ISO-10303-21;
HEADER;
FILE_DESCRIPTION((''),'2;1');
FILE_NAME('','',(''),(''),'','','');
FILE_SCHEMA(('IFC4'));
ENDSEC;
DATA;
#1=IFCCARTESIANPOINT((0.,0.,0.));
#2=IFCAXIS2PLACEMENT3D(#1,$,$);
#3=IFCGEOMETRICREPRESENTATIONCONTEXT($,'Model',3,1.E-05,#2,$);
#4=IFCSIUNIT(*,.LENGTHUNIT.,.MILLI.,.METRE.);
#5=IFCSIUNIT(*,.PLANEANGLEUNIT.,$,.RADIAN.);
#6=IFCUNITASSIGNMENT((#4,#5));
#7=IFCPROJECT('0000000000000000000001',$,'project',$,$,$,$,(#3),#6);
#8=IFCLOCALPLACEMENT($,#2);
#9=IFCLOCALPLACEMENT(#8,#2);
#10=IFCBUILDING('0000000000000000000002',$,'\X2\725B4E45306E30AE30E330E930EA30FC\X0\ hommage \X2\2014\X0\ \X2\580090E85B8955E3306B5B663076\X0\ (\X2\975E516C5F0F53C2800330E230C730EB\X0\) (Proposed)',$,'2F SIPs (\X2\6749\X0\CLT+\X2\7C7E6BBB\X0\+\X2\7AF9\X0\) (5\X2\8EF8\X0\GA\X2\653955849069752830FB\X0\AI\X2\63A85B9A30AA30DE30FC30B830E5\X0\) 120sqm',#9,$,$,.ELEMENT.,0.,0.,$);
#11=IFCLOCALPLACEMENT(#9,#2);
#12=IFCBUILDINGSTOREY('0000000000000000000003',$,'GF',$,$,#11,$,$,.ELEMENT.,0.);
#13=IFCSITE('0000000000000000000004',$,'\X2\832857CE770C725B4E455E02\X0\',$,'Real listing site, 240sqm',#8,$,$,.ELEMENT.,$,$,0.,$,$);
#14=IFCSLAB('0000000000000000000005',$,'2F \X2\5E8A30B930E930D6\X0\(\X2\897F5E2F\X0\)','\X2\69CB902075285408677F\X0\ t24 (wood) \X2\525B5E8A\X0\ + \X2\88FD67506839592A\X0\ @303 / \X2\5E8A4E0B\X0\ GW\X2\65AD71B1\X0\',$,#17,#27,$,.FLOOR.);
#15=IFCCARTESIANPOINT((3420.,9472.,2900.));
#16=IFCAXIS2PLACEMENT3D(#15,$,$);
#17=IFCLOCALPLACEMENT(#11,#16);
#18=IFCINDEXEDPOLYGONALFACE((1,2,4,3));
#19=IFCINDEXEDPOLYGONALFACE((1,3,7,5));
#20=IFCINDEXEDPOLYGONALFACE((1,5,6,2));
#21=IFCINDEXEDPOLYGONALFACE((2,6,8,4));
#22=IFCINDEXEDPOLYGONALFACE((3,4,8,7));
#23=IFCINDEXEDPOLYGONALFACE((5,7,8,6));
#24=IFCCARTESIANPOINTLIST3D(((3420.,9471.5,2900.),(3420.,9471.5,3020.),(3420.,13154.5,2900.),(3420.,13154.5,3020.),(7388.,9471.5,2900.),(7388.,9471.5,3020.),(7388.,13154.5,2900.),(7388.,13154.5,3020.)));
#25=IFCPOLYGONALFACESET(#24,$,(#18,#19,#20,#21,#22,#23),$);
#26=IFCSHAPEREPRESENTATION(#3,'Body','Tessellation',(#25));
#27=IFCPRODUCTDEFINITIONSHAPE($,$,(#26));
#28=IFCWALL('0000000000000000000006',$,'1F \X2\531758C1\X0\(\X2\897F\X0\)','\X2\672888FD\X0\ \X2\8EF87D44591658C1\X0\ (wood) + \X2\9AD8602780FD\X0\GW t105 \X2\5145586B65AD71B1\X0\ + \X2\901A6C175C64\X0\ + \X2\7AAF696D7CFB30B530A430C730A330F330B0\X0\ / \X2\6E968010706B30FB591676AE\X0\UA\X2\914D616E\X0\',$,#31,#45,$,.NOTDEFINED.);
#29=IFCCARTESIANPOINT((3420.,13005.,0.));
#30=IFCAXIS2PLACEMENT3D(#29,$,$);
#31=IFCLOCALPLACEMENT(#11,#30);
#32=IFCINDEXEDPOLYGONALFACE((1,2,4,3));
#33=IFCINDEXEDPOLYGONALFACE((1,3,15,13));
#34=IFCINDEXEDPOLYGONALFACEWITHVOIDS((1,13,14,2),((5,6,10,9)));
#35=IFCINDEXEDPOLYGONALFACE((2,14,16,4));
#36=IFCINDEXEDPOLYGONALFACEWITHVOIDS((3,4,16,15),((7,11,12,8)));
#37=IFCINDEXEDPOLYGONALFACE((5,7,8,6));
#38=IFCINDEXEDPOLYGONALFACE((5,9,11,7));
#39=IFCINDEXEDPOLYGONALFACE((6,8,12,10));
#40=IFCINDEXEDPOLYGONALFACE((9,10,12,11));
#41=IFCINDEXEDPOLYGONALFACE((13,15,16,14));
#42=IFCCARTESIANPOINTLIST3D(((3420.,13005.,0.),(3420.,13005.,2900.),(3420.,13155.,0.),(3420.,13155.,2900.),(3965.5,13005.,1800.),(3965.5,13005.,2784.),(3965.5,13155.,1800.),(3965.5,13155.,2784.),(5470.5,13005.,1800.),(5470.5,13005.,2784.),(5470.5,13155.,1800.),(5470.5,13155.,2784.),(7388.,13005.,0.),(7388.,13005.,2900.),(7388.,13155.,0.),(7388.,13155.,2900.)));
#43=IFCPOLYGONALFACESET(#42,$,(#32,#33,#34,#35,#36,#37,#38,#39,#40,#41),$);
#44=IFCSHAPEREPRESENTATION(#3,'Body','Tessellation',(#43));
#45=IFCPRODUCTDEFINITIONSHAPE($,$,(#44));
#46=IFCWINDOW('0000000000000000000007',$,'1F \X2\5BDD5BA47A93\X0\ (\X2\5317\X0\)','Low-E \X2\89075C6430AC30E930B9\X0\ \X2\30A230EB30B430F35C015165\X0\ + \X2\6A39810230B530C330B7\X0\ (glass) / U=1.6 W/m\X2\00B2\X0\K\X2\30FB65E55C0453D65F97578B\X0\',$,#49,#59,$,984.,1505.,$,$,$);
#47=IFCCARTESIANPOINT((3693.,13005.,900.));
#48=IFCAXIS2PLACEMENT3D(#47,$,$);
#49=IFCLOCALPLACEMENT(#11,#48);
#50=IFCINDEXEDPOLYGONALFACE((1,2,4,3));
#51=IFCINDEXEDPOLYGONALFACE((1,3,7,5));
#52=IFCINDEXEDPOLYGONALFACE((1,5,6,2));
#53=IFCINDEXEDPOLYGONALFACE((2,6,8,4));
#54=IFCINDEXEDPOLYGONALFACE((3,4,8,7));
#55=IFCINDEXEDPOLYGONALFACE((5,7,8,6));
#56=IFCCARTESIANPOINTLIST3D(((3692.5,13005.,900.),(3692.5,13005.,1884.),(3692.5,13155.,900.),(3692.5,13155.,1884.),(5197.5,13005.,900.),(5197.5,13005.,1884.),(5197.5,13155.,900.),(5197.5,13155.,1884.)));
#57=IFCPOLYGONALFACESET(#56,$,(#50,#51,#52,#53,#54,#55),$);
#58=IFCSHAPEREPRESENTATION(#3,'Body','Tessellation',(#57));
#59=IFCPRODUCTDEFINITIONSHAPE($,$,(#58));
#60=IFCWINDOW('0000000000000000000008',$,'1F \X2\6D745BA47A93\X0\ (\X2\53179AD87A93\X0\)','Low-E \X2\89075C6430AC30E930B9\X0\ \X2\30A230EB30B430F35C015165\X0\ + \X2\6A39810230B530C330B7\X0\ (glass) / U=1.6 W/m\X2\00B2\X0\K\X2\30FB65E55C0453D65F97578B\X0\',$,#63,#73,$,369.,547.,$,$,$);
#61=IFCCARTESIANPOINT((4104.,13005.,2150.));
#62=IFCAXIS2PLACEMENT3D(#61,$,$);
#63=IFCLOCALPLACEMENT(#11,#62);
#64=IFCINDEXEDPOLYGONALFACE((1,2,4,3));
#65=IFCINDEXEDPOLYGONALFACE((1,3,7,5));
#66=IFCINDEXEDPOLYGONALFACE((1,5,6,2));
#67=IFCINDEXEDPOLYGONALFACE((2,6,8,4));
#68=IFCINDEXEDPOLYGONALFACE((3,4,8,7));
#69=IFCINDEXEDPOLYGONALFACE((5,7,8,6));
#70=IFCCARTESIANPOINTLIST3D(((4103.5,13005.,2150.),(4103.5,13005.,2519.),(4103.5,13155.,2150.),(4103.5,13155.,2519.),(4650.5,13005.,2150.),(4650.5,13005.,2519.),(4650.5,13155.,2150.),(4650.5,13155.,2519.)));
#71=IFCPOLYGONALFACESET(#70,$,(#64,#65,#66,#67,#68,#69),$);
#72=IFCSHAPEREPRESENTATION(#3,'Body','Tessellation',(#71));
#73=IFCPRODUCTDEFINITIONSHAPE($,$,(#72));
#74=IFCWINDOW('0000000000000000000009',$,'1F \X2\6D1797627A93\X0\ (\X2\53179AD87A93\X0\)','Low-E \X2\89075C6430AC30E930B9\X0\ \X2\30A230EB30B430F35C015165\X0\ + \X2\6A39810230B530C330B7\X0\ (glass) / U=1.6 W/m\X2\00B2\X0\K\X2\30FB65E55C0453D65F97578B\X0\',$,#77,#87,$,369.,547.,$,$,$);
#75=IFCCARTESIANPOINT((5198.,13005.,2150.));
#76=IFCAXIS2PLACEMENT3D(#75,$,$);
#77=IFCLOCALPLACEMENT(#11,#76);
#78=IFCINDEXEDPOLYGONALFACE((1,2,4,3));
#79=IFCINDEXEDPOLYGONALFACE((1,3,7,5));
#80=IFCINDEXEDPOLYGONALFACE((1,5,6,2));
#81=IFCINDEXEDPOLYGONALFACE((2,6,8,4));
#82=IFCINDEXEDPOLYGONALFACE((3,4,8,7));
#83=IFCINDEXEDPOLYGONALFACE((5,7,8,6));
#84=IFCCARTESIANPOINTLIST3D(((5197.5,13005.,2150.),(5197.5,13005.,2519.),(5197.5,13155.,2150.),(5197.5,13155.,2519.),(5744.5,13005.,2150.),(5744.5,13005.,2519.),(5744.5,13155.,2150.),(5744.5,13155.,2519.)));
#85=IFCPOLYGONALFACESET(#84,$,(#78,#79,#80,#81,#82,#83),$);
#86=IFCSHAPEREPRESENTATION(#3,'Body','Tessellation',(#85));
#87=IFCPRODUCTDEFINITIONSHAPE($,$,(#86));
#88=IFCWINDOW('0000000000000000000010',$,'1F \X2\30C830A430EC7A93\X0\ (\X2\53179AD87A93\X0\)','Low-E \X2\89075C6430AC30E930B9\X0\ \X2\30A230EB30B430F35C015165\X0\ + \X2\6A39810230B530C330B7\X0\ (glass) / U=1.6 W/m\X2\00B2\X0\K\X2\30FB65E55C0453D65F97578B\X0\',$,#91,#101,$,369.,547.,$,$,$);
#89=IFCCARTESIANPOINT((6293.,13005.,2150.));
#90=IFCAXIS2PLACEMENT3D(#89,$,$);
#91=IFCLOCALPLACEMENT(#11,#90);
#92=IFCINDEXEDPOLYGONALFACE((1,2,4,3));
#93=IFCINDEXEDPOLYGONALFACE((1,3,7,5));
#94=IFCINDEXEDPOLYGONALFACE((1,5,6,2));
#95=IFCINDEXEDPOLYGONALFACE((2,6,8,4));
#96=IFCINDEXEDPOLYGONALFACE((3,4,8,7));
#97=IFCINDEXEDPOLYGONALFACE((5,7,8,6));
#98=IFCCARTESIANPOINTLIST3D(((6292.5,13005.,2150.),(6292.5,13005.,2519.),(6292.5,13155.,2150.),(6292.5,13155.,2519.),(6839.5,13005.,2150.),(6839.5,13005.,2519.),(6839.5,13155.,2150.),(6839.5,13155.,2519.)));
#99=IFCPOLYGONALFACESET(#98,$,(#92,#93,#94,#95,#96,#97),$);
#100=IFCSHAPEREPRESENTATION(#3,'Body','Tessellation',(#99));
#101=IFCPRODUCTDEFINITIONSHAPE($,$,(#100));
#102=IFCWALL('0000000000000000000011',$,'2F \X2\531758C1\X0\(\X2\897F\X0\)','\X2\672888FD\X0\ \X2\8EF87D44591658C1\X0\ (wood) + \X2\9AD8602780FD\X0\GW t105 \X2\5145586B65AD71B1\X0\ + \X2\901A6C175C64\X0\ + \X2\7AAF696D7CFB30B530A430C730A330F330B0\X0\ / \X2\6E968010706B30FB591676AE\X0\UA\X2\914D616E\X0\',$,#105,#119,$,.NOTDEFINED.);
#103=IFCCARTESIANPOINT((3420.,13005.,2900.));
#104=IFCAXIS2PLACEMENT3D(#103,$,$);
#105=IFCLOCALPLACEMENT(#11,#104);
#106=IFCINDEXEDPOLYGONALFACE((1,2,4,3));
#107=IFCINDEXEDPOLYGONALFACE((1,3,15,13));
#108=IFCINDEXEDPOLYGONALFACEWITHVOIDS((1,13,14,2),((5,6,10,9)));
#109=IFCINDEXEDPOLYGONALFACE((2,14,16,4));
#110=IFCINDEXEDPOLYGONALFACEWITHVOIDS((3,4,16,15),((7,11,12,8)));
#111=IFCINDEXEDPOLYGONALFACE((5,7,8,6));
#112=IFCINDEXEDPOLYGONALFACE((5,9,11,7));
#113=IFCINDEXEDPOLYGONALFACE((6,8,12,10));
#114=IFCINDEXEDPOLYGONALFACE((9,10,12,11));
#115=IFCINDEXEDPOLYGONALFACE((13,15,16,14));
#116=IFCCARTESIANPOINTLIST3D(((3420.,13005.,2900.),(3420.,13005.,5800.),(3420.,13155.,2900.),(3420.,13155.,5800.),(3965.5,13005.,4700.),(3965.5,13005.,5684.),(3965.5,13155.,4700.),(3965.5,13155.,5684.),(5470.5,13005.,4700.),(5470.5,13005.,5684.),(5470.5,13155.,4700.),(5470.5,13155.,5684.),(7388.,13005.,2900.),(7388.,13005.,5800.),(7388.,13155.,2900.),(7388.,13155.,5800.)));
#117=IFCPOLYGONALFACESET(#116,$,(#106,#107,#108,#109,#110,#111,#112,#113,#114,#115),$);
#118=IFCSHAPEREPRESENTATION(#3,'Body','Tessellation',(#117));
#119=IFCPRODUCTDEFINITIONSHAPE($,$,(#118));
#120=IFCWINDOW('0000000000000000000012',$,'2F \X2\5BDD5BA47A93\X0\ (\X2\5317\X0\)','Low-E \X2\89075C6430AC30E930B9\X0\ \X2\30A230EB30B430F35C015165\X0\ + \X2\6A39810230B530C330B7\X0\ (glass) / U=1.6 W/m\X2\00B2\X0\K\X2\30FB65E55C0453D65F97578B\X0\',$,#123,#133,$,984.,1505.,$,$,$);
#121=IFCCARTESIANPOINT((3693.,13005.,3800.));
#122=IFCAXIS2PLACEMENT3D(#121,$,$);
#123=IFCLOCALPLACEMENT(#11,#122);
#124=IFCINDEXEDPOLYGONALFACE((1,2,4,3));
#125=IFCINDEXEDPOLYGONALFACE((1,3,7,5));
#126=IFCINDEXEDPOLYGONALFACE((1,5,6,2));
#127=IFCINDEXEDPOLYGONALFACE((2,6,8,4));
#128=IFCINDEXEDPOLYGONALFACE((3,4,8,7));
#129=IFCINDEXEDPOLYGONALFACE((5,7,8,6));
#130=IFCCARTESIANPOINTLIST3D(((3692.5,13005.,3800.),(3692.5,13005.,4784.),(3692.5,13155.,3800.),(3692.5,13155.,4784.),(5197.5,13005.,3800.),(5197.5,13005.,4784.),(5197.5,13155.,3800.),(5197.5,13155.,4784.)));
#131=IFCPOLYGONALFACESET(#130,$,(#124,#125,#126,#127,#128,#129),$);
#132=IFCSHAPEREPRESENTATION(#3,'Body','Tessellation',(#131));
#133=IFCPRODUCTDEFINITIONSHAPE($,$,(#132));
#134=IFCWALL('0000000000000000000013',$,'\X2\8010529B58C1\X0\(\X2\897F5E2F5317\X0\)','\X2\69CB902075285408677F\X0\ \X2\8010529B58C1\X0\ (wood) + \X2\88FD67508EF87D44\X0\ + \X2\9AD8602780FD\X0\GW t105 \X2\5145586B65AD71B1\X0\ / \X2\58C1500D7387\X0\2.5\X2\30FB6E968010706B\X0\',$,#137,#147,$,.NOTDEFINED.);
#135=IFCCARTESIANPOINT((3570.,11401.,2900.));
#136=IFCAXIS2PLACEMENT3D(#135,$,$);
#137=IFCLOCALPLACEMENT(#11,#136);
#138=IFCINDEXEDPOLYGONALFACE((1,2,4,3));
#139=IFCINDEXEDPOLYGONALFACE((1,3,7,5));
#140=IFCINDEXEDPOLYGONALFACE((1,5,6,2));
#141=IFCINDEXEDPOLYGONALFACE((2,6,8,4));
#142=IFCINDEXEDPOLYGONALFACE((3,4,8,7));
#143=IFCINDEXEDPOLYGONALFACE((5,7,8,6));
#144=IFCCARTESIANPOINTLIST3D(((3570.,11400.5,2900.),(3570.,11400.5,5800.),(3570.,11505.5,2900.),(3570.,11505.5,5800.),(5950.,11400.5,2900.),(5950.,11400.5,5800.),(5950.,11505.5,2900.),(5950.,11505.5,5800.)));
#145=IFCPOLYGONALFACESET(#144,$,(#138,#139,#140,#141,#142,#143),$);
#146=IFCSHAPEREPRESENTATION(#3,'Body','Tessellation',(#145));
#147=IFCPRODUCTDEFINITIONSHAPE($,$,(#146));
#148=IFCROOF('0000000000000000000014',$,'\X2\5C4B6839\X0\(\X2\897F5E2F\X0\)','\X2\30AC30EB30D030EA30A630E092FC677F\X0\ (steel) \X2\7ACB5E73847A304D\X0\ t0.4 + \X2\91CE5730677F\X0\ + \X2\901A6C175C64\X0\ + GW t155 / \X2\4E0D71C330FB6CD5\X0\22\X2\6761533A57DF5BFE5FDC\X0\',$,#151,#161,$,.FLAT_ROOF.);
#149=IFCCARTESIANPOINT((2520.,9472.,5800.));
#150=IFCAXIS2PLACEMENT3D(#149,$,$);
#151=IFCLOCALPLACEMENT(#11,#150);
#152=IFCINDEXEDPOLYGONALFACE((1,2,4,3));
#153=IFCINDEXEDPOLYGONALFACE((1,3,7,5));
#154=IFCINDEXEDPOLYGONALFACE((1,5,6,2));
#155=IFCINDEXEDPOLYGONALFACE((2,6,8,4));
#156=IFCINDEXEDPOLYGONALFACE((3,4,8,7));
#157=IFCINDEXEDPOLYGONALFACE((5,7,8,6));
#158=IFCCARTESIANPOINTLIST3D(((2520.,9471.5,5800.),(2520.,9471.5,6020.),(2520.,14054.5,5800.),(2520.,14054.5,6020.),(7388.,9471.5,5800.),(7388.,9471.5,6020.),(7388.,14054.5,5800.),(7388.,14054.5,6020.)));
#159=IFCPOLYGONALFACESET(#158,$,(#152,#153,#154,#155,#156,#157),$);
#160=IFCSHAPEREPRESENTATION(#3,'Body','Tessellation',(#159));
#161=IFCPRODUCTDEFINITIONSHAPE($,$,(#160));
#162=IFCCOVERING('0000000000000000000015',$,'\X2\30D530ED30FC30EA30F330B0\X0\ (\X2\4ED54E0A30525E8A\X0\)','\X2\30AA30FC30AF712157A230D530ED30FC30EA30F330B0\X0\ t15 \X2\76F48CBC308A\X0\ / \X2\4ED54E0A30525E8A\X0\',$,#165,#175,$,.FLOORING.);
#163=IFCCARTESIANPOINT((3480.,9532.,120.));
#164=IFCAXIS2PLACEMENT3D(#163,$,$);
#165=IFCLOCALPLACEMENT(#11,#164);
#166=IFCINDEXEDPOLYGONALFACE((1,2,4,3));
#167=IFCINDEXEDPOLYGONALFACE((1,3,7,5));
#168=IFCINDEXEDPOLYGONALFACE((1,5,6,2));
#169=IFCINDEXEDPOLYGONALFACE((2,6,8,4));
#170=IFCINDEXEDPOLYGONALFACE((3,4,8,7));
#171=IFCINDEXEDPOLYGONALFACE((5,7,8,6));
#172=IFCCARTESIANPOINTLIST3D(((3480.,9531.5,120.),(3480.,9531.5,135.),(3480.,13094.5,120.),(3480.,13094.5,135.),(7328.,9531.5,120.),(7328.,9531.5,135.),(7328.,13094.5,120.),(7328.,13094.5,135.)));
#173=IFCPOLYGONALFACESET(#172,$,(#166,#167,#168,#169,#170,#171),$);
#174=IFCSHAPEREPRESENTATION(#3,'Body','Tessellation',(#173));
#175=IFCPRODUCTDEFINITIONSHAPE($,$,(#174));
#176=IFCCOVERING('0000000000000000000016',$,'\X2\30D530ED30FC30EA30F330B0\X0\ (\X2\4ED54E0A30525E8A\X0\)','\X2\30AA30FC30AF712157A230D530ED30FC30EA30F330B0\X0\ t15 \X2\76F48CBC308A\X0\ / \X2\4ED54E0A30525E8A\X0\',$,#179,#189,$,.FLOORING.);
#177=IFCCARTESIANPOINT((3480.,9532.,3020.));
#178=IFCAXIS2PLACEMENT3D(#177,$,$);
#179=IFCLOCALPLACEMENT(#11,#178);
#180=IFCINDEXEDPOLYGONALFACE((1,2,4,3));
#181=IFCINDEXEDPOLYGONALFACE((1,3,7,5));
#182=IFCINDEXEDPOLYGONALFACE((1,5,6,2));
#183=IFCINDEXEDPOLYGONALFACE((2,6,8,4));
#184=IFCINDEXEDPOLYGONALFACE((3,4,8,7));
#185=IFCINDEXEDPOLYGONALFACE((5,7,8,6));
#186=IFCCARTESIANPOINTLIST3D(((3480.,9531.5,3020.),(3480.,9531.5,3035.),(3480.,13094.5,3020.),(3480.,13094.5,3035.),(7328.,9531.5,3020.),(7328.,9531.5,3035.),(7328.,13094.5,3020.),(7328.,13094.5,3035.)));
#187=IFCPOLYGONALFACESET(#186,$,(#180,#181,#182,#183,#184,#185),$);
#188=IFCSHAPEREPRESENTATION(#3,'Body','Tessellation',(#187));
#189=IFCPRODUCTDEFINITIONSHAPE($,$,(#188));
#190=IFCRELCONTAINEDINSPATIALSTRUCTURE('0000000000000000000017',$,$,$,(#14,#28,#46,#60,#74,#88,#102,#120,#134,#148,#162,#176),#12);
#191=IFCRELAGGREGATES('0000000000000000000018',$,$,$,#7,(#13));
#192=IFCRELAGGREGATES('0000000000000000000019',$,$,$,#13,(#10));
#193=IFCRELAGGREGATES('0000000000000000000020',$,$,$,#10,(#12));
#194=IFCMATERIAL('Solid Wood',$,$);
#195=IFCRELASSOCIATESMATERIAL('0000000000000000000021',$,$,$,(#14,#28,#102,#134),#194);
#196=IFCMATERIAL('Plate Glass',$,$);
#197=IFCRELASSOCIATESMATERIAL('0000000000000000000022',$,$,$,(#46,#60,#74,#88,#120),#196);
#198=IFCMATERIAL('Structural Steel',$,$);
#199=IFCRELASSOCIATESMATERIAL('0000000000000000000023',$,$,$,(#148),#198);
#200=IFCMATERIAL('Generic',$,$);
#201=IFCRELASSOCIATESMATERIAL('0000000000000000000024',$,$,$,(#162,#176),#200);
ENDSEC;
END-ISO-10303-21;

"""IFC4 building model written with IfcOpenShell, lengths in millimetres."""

from ifc_helpers import new_model, si_unit, frame, frame_2d, origin, place, context, project, spatial, rectangle, extrude, material, element, fill, save


model = new_model("IFC4")

# Units and contexts
model_context = context("Model", 3, precision=1e-05, world=origin())
ifc_project = project(units=[si_unit("LENGTHUNIT", "METRE", prefix="MILLI"), si_unit("PLANEANGLEUNIT", "RADIAN")], contexts=[model_context])

# Site, building, storey
site_placement = place(None, origin())
site = spatial("IfcSite", under=ifc_project, at=site_placement, Name="茨城県牛久市", ObjectType="Real listing site, 240sqm", CompositionType="ELEMENT", RefElevation=0.0)
building_placement = place(site_placement, origin())
building = spatial("IfcBuilding", under=site, at=building_placement, Name="牛久のギャラリー hommage — 堀部安嗣に学ぶ (非公式参考モデル) (Proposed)", ObjectType="2F SIPs (杉CLT+籾殻+竹) (5軸GA改善適用・AI推定オマージュ) 120sqm", CompositionType="ELEMENT", ElevationOfRefHeight=0.0, ElevationOfTerrain=0.0)
storey_placement = place(building_placement, origin())
storey = spatial("IfcBuildingStorey", under=building, at=storey_placement, Name="GF", CompositionType="ELEMENT", Elevation=0.0)

# Slab
ifc_material_1 = material(Name="Solid Wood")
slab_1_placement = place(storey_placement, frame((3420.0, 9472.0, 2900.0)))
element("IfcSlab", 1, at=slab_1_placement, inside=storey, material=ifc_material_1, Name="2F 床スラブ(西帯)", Description="構造用合板 t24 (wood) 剛床 + 製材根太 @303 / 床下 GW断熱", PredefinedType="FLOOR", context=model_context, shape_type="SweptSolid", body=[
    extrude(rectangle(XDim=3968.0, YDim=3683.0, at=frame_2d((1984.0, 1841.0))), frame((3420.0, 9472.0, 2900.0)), (0.0, 0.0, 1.0), 120.0),
])

# Wall, openings, windows
wall_1_placement = place(storey_placement, frame((3420.0, 13005.0, 0.0)))
wall_1 = element("IfcWall", 2, at=wall_1_placement, inside=storey, material=ifc_material_1, Name="1F 北壁(西)", Description="木製 軸組外壁 (wood) + 高性能GW t105 充填断熱 + 通気層 + 窯業系サイディング / 準耐火・外皮UA配慮", PredefinedType="NOTDEFINED", context=model_context, shape_type="SweptSolid", body=[
    extrude(rectangle(XDim=3968.0, YDim=150.0, at=frame_2d((1984.0, 75.0))), frame((3420.0, 13005.0, 0.0)), (0.0, 0.0, 1.0), 2900.0),
])
opening_1_placement = place(storey_placement, frame((3693.0, 13005.0, 900.0)))
opening_1 = element("IfcOpeningElement", 3, at=opening_1_placement, cuts=wall_1, PredefinedType="NOTDEFINED", context=model_context, shape_type="SweptSolid", body=[
    extrude(rectangle(XDim=1505.0, YDim=150.0, at=frame_2d((752.0, 75.0))), frame((3693.0, 13005.0, 900.0)), (0.0, 0.0, 1.0), 984.0),
])
opening_2_placement = place(storey_placement, frame((4104.0, 13005.0, 2150.0)))
opening_2 = element("IfcOpeningElement", 4, at=opening_2_placement, cuts=wall_1, PredefinedType="NOTDEFINED", context=model_context, shape_type="SweptSolid", body=[
    extrude(rectangle(XDim=547.0, YDim=150.0, at=frame_2d((273.0, 75.0))), frame((4104.0, 13005.0, 2150.0)), (0.0, 0.0, 1.0), 369.0),
])
opening_3_placement = place(storey_placement, frame((5198.0, 13005.0, 2150.0)))
opening_3 = element("IfcOpeningElement", 5, at=opening_3_placement, cuts=wall_1, PredefinedType="NOTDEFINED", context=model_context, shape_type="SweptSolid", body=[
    extrude(rectangle(XDim=547.0, YDim=150.0, at=frame_2d((273.0, 75.0))), frame((5198.0, 13005.0, 2150.0)), (0.0, 0.0, 1.0), 369.0),
])
opening_4_placement = place(storey_placement, frame((6293.0, 13005.0, 2150.0)))
opening_4 = element("IfcOpeningElement", 6, at=opening_4_placement, cuts=wall_1, PredefinedType="NOTDEFINED", context=model_context, shape_type="SweptSolid", body=[
    extrude(rectangle(XDim=547.0, YDim=150.0, at=frame_2d((273.0, 75.0))), frame((6293.0, 13005.0, 2150.0)), (0.0, 0.0, 1.0), 369.0),
])
ifc_material_2 = material(Name="Plate Glass")
window_1_placement = place(storey_placement, frame((3693.0, 13005.0, 900.0)))
window_1 = element("IfcWindow", 7, at=window_1_placement, inside=storey, material=ifc_material_2, Name="1F 寝室窓 (北)", Description="Low-E 複層ガラス アルゴン封入 + 樹脂サッシ (glass) / U=1.6 W/m²K・日射取得型", OverallHeight=984.0, OverallWidth=1505.0, context=model_context, shape_type="SweptSolid", body=[
    extrude(rectangle(XDim=1505.0, YDim=150.0, at=frame_2d((752.0, 75.0))), frame((3693.0, 13005.0, 900.0)), (0.0, 0.0, 1.0), 984.0),
])
fill(opening_1, window_1)
window_2_placement = place(storey_placement, frame((4104.0, 13005.0, 2150.0)))
window_2 = element("IfcWindow", 8, at=window_2_placement, inside=storey, material=ifc_material_2, Name="1F 浴室窓 (北高窓)", Description="Low-E 複層ガラス アルゴン封入 + 樹脂サッシ (glass) / U=1.6 W/m²K・日射取得型", OverallHeight=369.0, OverallWidth=547.0, context=model_context, shape_type="SweptSolid", body=[
    extrude(rectangle(XDim=547.0, YDim=150.0, at=frame_2d((273.0, 75.0))), frame((4104.0, 13005.0, 2150.0)), (0.0, 0.0, 1.0), 369.0),
])
fill(opening_2, window_2)
window_3_placement = place(storey_placement, frame((5198.0, 13005.0, 2150.0)))
window_3 = element("IfcWindow", 9, at=window_3_placement, inside=storey, material=ifc_material_2, Name="1F 洗面窓 (北高窓)", Description="Low-E 複層ガラス アルゴン封入 + 樹脂サッシ (glass) / U=1.6 W/m²K・日射取得型", OverallHeight=369.0, OverallWidth=547.0, context=model_context, shape_type="SweptSolid", body=[
    extrude(rectangle(XDim=547.0, YDim=150.0, at=frame_2d((273.0, 75.0))), frame((5198.0, 13005.0, 2150.0)), (0.0, 0.0, 1.0), 369.0),
])
fill(opening_3, window_3)
window_4_placement = place(storey_placement, frame((6293.0, 13005.0, 2150.0)))
window_4 = element("IfcWindow", 10, at=window_4_placement, inside=storey, material=ifc_material_2, Name="1F トイレ窓 (北高窓)", Description="Low-E 複層ガラス アルゴン封入 + 樹脂サッシ (glass) / U=1.6 W/m²K・日射取得型", OverallHeight=369.0, OverallWidth=547.0, context=model_context, shape_type="SweptSolid", body=[
    extrude(rectangle(XDim=547.0, YDim=150.0, at=frame_2d((273.0, 75.0))), frame((6293.0, 13005.0, 2150.0)), (0.0, 0.0, 1.0), 369.0),
])
fill(opening_4, window_4)

# Wall, opening, window
wall_2_placement = place(storey_placement, frame((3420.0, 13005.0, 2900.0)))
wall_2 = element("IfcWall", 11, at=wall_2_placement, inside=storey, material=ifc_material_1, Name="2F 北壁(西)", Description="木製 軸組外壁 (wood) + 高性能GW t105 充填断熱 + 通気層 + 窯業系サイディング / 準耐火・外皮UA配慮", PredefinedType="NOTDEFINED", context=model_context, shape_type="SweptSolid", body=[
    extrude(rectangle(XDim=3968.0, YDim=150.0, at=frame_2d((1984.0, 75.0))), frame((3420.0, 13005.0, 2900.0)), (0.0, 0.0, 1.0), 2900.0),
])
opening_5_placement = place(storey_placement, frame((3693.0, 13005.0, 3800.0)))
opening_5 = element("IfcOpeningElement", 12, at=opening_5_placement, cuts=wall_2, PredefinedType="NOTDEFINED", context=model_context, shape_type="SweptSolid", body=[
    extrude(rectangle(XDim=1505.0, YDim=150.0, at=frame_2d((752.0, 75.0))), frame((3693.0, 13005.0, 3800.0)), (0.0, 0.0, 1.0), 984.0),
])
window_5_placement = place(storey_placement, frame((3693.0, 13005.0, 3800.0)))
window_5 = element("IfcWindow", 13, at=window_5_placement, inside=storey, material=ifc_material_2, Name="2F 寝室窓 (北)", Description="Low-E 複層ガラス アルゴン封入 + 樹脂サッシ (glass) / U=1.6 W/m²K・日射取得型", OverallHeight=984.0, OverallWidth=1505.0, context=model_context, shape_type="SweptSolid", body=[
    extrude(rectangle(XDim=1505.0, YDim=150.0, at=frame_2d((752.0, 75.0))), frame((3693.0, 13005.0, 3800.0)), (0.0, 0.0, 1.0), 984.0),
])
fill(opening_5, window_5)

# Wall
wall_3_placement = place(storey_placement, frame((3570.0, 11401.0, 2900.0)))
element("IfcWall", 14, at=wall_3_placement, inside=storey, material=ifc_material_1, Name="耐力壁(西帯北)", Description="構造用合板 耐力壁 (wood) + 製材軸組 + 高性能GW t105 充填断熱 / 壁倍率2.5・準耐火", PredefinedType="NOTDEFINED", context=model_context, shape_type="SweptSolid", body=[
    extrude(rectangle(XDim=2380.0, YDim=105.0, at=frame_2d((1190.0, 52.0))), frame((3570.0, 11401.0, 2900.0)), (0.0, 0.0, 1.0), 2900.0),
])

# Roof
ifc_material_3 = material(Name="Structural Steel")
for number, where, name in (
    (15, (2520.0, 9472.0, 5800.0), "屋根(西帯)"),
):
    element("IfcRoof", number, at=place(storey_placement, frame(where)), inside=storey, material=ifc_material_3, Name=name, Description="ガルバリウム鋼板 (steel) 立平葺き t0.4 + 野地板 + 通気層 + GW t155 / 不燃・法22条区域対応", PredefinedType="FLAT_ROOF", context=model_context, shape_type="SweptSolid", body=[
        extrude(rectangle(XDim=4868.0, YDim=4583.0, at=frame_2d((2434.0, 2291.0))), frame((2520.0, 9472.0, 5800.0)), (0.0, 0.0, 1.0), 220.0),
    ])

# Coverings
ifc_material_4 = material(Name="Generic")
covering_1_placement = place(storey_placement, frame((3480.0, 9532.0, 120.0)))
element("IfcCovering", 16, at=covering_1_placement, inside=storey, material=ifc_material_4, Name="フローリング (仕上げ床)", Description="オーク無垢フローリング t15 直貼り / 仕上げ床", PredefinedType="FLOORING", context=model_context, shape_type="SweptSolid", body=[
    extrude(rectangle(XDim=3848.0, YDim=3563.0, at=frame_2d((1924.0, 1781.0))), frame((3480.0, 9532.0, 120.0)), (0.0, 0.0, 1.0), 15.0),
])
covering_2_placement = place(storey_placement, frame((3480.0, 9532.0, 3020.0)))
element("IfcCovering", 17, at=covering_2_placement, inside=storey, material=ifc_material_4, Name="フローリング (仕上げ床)", Description="オーク無垢フローリング t15 直貼り / 仕上げ床", PredefinedType="FLOORING", context=model_context, shape_type="SweptSolid", body=[
    extrude(rectangle(XDim=3848.0, YDim=3563.0, at=frame_2d((1924.0, 1781.0))), frame((3480.0, 9532.0, 3020.0)), (0.0, 0.0, 1.0), 15.0),
])

save(model, "model.ifc")
